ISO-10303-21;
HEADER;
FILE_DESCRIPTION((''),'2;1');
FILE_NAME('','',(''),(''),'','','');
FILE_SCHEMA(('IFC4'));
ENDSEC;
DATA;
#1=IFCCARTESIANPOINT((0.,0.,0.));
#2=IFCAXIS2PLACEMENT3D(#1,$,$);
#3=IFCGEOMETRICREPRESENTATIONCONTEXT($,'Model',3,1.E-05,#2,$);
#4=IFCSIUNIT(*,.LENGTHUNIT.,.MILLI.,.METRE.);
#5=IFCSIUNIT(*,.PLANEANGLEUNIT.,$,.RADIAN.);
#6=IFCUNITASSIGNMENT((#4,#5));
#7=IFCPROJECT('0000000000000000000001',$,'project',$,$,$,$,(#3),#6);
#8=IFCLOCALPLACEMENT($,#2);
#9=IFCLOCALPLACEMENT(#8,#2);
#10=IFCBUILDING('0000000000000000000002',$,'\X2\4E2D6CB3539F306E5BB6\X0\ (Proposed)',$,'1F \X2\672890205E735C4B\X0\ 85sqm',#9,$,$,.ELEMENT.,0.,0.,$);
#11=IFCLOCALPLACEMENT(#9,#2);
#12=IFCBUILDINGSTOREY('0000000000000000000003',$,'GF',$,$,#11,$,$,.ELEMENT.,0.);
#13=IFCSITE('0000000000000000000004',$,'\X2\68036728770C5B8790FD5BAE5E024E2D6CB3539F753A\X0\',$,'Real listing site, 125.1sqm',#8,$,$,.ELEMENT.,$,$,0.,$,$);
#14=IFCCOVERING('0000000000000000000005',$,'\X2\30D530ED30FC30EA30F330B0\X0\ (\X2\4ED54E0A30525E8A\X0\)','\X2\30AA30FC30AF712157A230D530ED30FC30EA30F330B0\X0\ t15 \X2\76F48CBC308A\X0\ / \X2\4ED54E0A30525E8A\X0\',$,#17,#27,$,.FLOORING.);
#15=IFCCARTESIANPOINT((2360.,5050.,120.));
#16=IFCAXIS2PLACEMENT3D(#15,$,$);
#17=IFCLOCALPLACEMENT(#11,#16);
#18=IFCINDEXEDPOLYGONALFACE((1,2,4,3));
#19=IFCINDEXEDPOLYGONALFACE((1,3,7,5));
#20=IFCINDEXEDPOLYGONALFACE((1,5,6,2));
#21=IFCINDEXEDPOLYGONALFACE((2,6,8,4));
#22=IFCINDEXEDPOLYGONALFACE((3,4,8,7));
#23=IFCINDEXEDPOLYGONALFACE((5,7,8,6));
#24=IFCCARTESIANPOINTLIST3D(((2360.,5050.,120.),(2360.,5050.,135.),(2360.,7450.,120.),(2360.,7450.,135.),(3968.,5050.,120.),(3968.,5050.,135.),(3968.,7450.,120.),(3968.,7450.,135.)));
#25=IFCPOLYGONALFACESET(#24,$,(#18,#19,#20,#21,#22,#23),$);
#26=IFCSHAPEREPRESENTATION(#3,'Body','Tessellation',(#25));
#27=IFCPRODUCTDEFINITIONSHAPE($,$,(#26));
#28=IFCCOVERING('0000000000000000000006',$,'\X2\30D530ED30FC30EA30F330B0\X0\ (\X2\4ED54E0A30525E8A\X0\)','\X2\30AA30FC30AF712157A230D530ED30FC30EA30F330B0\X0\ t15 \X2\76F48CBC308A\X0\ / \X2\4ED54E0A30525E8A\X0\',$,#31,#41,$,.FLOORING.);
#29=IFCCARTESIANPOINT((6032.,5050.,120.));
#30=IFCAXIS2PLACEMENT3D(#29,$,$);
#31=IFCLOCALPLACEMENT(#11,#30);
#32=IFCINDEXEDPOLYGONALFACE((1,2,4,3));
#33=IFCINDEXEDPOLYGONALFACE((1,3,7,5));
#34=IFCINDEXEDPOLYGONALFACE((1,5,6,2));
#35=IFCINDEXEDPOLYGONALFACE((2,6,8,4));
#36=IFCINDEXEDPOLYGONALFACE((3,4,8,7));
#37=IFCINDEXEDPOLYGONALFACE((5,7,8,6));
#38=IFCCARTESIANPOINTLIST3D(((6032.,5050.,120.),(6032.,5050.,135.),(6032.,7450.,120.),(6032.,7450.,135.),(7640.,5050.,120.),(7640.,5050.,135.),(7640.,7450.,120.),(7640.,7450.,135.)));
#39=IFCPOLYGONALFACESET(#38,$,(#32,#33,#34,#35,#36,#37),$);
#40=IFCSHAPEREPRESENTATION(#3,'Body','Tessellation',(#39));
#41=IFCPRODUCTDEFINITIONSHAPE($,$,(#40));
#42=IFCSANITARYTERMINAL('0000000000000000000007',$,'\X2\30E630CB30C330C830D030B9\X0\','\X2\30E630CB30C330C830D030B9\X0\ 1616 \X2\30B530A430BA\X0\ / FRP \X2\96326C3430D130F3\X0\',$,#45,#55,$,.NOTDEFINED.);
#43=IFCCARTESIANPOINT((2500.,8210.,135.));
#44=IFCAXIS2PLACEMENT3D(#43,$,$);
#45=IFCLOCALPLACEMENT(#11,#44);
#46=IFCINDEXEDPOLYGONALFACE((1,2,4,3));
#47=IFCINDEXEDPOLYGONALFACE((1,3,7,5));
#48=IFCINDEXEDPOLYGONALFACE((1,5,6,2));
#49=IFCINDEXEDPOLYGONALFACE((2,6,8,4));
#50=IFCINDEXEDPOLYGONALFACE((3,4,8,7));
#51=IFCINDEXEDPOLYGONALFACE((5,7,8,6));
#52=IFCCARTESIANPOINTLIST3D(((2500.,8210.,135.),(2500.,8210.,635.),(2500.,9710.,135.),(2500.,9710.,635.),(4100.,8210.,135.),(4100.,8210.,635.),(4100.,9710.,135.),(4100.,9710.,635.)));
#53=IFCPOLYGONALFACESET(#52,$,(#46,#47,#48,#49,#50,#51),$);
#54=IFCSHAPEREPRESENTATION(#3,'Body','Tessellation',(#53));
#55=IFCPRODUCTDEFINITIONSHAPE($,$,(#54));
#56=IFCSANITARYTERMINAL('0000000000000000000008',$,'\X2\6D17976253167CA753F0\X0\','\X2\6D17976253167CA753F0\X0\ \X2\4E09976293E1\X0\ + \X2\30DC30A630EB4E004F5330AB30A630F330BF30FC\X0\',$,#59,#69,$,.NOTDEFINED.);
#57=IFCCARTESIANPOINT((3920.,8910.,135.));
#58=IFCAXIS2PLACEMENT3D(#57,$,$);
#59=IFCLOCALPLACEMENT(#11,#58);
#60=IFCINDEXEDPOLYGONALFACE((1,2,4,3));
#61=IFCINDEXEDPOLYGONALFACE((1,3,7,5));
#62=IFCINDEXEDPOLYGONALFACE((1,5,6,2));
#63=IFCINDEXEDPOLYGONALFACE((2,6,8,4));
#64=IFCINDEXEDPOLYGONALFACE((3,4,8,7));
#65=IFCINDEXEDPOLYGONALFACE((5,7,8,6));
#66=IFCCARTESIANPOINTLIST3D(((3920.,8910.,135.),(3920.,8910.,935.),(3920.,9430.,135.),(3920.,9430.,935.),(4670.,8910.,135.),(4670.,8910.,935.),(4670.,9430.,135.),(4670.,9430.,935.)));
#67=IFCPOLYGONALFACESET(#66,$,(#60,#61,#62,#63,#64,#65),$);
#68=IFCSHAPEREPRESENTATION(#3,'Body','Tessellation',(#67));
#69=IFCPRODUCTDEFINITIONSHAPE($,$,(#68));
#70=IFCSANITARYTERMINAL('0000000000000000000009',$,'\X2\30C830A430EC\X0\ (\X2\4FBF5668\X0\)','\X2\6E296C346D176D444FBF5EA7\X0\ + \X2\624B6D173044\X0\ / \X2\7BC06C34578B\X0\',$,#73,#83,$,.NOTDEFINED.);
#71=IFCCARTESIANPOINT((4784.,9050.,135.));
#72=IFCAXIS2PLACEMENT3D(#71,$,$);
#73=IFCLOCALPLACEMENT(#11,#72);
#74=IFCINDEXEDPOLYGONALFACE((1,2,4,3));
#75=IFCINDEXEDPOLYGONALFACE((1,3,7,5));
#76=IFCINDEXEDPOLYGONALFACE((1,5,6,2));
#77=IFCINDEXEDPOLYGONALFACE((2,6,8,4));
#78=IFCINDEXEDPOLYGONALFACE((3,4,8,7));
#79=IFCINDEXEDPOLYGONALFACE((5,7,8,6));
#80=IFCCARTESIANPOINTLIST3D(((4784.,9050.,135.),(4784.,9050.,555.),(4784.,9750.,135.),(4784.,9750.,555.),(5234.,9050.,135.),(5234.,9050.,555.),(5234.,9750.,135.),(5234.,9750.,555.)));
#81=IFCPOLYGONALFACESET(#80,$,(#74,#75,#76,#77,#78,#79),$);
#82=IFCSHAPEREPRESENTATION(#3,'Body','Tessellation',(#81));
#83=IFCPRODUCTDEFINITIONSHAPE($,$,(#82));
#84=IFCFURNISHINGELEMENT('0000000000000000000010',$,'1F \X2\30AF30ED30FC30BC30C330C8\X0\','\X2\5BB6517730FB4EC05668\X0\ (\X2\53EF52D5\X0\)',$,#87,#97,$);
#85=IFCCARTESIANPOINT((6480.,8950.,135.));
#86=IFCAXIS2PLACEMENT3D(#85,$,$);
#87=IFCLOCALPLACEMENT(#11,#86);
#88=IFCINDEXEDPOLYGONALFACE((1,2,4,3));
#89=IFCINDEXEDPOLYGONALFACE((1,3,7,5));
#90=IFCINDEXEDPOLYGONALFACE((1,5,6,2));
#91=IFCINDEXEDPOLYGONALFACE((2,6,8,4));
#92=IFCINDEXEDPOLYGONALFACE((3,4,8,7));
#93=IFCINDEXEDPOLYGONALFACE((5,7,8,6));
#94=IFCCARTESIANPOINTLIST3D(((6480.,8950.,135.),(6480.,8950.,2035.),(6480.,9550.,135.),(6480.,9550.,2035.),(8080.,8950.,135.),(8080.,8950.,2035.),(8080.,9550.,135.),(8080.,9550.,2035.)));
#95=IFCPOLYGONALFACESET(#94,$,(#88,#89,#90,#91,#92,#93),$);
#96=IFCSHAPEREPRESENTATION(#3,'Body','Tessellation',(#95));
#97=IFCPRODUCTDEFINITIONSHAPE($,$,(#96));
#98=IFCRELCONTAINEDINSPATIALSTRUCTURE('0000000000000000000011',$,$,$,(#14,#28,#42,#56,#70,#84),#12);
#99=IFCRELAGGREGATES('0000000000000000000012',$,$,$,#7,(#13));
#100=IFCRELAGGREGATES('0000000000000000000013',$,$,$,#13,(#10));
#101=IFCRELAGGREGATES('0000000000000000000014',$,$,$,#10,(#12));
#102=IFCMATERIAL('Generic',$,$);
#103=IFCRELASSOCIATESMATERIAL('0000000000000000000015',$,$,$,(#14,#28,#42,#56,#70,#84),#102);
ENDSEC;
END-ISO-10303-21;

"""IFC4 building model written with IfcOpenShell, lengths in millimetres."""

from ifc_helpers import new_model, si_unit, frame, frame_2d, origin, place, context, project, spatial, rectangle, extrude, material, element, save


model = new_model("IFC4")

# Units and contexts
model_context = context("Model", 3, precision=1e-05, world=origin())
ifc_project = project(units=[si_unit("LENGTHUNIT", "METRE", prefix="MILLI"), si_unit("PLANEANGLEUNIT", "RADIAN")], contexts=[model_context])

# Site, building, storey
site_placement = place(None, origin())
site = spatial("IfcSite", under=ifc_project, at=site_placement, Name="栃木県宇都宮市中河原町", ObjectType="Real listing site, 125.1sqm", CompositionType="ELEMENT", RefElevation=0.0)
building_placement = place(site_placement, origin())
building = spatial("IfcBuilding", under=site, at=building_placement, Name="中河原の家 (Proposed)", ObjectType="1F 木造平屋 85sqm", CompositionType="ELEMENT", ElevationOfRefHeight=0.0, ElevationOfTerrain=0.0)
storey_placement = place(building_placement, origin())
storey = spatial("IfcBuildingStorey", under=building, at=storey_placement, Name="GF", CompositionType="ELEMENT", Elevation=0.0)

# Coverings
ifc_material_1 = material(Name="Generic")
covering_1_placement = place(storey_placement, frame((2360.0, 5050.0, 120.0)))
element("IfcCovering", 1, at=covering_1_placement, inside=storey, material=ifc_material_1, Name="フローリング (仕上げ床)", Description="オーク無垢フローリング t15 直貼り / 仕上げ床", PredefinedType="FLOORING", context=model_context, shape_type="SweptSolid", body=[
    extrude(rectangle(XDim=1608.0, YDim=2400.0, at=frame_2d((804.0, 1200.0))), frame((2360.0, 5050.0, 120.0)), (0.0, 0.0, 1.0), 15.0),
])
covering_2_placement = place(storey_placement, frame((6032.0, 5050.0, 120.0)))
element("IfcCovering", 2, at=covering_2_placement, inside=storey, material=ifc_material_1, Name="フローリング (仕上げ床)", Description="オーク無垢フローリング t15 直貼り / 仕上げ床", PredefinedType="FLOORING", context=model_context, shape_type="SweptSolid", body=[
    extrude(rectangle(XDim=1608.0, YDim=2400.0, at=frame_2d((804.0, 1200.0))), frame((6032.0, 5050.0, 120.0)), (0.0, 0.0, 1.0), 15.0),
])

# Sanitary terminals
sanitary_terminal_1_placement = place(storey_placement, frame((2500.0, 8210.0, 135.0)))
element("IfcSanitaryTerminal", 3, at=sanitary_terminal_1_placement, inside=storey, material=ifc_material_1, Name="ユニットバス", Description="ユニットバス 1616 サイズ / FRP 防水パン", PredefinedType="NOTDEFINED", context=model_context, shape_type="SweptSolid", body=[
    extrude(rectangle(XDim=1600.0, YDim=1500.0, at=frame_2d((800.0, 750.0))), frame((2500.0, 8210.0, 135.0)), (0.0, 0.0, 1.0), 500.0),
])
sanitary_terminal_2_placement = place(storey_placement, frame((3920.0, 8910.0, 135.0)))
element("IfcSanitaryTerminal", 4, at=sanitary_terminal_2_placement, inside=storey, material=ifc_material_1, Name="洗面化粧台", Description="洗面化粧台 三面鏡 + ボウル一体カウンター", PredefinedType="NOTDEFINED", context=model_context, shape_type="SweptSolid", body=[
    extrude(rectangle(XDim=750.0, YDim=520.0, at=frame_2d((375.0, 260.0))), frame((3920.0, 8910.0, 135.0)), (0.0, 0.0, 1.0), 800.0),
])
sanitary_terminal_3_placement = place(storey_placement, frame((4784.0, 9050.0, 135.0)))
element("IfcSanitaryTerminal", 5, at=sanitary_terminal_3_placement, inside=storey, material=ifc_material_1, Name="トイレ (便器)", Description="温水洗浄便座 + 手洗い / 節水型", PredefinedType="NOTDEFINED", context=model_context, shape_type="SweptSolid", body=[
    extrude(rectangle(XDim=450.0, YDim=700.0, at=frame_2d((225.0, 350.0))), frame((4784.0, 9050.0, 135.0)), (0.0, 0.0, 1.0), 420.0),
])

# Furnishing element
furnishing_placement = place(storey_placement, frame((6480.0, 8950.0, 135.0)))
element("IfcFurnishingElement", 6, at=furnishing_placement, inside=storey, material=ifc_material_1, Name="1F クローゼット", Description="家具・什器 (可動)", context=model_context, shape_type="SweptSolid", body=[
    extrude(rectangle(XDim=1600.0, YDim=600.0, at=frame_2d((800.0, 300.0))), frame((6480.0, 8950.0, 135.0)), (0.0, 0.0, 1.0), 1900.0),
])

save(model, "model.ifc")
